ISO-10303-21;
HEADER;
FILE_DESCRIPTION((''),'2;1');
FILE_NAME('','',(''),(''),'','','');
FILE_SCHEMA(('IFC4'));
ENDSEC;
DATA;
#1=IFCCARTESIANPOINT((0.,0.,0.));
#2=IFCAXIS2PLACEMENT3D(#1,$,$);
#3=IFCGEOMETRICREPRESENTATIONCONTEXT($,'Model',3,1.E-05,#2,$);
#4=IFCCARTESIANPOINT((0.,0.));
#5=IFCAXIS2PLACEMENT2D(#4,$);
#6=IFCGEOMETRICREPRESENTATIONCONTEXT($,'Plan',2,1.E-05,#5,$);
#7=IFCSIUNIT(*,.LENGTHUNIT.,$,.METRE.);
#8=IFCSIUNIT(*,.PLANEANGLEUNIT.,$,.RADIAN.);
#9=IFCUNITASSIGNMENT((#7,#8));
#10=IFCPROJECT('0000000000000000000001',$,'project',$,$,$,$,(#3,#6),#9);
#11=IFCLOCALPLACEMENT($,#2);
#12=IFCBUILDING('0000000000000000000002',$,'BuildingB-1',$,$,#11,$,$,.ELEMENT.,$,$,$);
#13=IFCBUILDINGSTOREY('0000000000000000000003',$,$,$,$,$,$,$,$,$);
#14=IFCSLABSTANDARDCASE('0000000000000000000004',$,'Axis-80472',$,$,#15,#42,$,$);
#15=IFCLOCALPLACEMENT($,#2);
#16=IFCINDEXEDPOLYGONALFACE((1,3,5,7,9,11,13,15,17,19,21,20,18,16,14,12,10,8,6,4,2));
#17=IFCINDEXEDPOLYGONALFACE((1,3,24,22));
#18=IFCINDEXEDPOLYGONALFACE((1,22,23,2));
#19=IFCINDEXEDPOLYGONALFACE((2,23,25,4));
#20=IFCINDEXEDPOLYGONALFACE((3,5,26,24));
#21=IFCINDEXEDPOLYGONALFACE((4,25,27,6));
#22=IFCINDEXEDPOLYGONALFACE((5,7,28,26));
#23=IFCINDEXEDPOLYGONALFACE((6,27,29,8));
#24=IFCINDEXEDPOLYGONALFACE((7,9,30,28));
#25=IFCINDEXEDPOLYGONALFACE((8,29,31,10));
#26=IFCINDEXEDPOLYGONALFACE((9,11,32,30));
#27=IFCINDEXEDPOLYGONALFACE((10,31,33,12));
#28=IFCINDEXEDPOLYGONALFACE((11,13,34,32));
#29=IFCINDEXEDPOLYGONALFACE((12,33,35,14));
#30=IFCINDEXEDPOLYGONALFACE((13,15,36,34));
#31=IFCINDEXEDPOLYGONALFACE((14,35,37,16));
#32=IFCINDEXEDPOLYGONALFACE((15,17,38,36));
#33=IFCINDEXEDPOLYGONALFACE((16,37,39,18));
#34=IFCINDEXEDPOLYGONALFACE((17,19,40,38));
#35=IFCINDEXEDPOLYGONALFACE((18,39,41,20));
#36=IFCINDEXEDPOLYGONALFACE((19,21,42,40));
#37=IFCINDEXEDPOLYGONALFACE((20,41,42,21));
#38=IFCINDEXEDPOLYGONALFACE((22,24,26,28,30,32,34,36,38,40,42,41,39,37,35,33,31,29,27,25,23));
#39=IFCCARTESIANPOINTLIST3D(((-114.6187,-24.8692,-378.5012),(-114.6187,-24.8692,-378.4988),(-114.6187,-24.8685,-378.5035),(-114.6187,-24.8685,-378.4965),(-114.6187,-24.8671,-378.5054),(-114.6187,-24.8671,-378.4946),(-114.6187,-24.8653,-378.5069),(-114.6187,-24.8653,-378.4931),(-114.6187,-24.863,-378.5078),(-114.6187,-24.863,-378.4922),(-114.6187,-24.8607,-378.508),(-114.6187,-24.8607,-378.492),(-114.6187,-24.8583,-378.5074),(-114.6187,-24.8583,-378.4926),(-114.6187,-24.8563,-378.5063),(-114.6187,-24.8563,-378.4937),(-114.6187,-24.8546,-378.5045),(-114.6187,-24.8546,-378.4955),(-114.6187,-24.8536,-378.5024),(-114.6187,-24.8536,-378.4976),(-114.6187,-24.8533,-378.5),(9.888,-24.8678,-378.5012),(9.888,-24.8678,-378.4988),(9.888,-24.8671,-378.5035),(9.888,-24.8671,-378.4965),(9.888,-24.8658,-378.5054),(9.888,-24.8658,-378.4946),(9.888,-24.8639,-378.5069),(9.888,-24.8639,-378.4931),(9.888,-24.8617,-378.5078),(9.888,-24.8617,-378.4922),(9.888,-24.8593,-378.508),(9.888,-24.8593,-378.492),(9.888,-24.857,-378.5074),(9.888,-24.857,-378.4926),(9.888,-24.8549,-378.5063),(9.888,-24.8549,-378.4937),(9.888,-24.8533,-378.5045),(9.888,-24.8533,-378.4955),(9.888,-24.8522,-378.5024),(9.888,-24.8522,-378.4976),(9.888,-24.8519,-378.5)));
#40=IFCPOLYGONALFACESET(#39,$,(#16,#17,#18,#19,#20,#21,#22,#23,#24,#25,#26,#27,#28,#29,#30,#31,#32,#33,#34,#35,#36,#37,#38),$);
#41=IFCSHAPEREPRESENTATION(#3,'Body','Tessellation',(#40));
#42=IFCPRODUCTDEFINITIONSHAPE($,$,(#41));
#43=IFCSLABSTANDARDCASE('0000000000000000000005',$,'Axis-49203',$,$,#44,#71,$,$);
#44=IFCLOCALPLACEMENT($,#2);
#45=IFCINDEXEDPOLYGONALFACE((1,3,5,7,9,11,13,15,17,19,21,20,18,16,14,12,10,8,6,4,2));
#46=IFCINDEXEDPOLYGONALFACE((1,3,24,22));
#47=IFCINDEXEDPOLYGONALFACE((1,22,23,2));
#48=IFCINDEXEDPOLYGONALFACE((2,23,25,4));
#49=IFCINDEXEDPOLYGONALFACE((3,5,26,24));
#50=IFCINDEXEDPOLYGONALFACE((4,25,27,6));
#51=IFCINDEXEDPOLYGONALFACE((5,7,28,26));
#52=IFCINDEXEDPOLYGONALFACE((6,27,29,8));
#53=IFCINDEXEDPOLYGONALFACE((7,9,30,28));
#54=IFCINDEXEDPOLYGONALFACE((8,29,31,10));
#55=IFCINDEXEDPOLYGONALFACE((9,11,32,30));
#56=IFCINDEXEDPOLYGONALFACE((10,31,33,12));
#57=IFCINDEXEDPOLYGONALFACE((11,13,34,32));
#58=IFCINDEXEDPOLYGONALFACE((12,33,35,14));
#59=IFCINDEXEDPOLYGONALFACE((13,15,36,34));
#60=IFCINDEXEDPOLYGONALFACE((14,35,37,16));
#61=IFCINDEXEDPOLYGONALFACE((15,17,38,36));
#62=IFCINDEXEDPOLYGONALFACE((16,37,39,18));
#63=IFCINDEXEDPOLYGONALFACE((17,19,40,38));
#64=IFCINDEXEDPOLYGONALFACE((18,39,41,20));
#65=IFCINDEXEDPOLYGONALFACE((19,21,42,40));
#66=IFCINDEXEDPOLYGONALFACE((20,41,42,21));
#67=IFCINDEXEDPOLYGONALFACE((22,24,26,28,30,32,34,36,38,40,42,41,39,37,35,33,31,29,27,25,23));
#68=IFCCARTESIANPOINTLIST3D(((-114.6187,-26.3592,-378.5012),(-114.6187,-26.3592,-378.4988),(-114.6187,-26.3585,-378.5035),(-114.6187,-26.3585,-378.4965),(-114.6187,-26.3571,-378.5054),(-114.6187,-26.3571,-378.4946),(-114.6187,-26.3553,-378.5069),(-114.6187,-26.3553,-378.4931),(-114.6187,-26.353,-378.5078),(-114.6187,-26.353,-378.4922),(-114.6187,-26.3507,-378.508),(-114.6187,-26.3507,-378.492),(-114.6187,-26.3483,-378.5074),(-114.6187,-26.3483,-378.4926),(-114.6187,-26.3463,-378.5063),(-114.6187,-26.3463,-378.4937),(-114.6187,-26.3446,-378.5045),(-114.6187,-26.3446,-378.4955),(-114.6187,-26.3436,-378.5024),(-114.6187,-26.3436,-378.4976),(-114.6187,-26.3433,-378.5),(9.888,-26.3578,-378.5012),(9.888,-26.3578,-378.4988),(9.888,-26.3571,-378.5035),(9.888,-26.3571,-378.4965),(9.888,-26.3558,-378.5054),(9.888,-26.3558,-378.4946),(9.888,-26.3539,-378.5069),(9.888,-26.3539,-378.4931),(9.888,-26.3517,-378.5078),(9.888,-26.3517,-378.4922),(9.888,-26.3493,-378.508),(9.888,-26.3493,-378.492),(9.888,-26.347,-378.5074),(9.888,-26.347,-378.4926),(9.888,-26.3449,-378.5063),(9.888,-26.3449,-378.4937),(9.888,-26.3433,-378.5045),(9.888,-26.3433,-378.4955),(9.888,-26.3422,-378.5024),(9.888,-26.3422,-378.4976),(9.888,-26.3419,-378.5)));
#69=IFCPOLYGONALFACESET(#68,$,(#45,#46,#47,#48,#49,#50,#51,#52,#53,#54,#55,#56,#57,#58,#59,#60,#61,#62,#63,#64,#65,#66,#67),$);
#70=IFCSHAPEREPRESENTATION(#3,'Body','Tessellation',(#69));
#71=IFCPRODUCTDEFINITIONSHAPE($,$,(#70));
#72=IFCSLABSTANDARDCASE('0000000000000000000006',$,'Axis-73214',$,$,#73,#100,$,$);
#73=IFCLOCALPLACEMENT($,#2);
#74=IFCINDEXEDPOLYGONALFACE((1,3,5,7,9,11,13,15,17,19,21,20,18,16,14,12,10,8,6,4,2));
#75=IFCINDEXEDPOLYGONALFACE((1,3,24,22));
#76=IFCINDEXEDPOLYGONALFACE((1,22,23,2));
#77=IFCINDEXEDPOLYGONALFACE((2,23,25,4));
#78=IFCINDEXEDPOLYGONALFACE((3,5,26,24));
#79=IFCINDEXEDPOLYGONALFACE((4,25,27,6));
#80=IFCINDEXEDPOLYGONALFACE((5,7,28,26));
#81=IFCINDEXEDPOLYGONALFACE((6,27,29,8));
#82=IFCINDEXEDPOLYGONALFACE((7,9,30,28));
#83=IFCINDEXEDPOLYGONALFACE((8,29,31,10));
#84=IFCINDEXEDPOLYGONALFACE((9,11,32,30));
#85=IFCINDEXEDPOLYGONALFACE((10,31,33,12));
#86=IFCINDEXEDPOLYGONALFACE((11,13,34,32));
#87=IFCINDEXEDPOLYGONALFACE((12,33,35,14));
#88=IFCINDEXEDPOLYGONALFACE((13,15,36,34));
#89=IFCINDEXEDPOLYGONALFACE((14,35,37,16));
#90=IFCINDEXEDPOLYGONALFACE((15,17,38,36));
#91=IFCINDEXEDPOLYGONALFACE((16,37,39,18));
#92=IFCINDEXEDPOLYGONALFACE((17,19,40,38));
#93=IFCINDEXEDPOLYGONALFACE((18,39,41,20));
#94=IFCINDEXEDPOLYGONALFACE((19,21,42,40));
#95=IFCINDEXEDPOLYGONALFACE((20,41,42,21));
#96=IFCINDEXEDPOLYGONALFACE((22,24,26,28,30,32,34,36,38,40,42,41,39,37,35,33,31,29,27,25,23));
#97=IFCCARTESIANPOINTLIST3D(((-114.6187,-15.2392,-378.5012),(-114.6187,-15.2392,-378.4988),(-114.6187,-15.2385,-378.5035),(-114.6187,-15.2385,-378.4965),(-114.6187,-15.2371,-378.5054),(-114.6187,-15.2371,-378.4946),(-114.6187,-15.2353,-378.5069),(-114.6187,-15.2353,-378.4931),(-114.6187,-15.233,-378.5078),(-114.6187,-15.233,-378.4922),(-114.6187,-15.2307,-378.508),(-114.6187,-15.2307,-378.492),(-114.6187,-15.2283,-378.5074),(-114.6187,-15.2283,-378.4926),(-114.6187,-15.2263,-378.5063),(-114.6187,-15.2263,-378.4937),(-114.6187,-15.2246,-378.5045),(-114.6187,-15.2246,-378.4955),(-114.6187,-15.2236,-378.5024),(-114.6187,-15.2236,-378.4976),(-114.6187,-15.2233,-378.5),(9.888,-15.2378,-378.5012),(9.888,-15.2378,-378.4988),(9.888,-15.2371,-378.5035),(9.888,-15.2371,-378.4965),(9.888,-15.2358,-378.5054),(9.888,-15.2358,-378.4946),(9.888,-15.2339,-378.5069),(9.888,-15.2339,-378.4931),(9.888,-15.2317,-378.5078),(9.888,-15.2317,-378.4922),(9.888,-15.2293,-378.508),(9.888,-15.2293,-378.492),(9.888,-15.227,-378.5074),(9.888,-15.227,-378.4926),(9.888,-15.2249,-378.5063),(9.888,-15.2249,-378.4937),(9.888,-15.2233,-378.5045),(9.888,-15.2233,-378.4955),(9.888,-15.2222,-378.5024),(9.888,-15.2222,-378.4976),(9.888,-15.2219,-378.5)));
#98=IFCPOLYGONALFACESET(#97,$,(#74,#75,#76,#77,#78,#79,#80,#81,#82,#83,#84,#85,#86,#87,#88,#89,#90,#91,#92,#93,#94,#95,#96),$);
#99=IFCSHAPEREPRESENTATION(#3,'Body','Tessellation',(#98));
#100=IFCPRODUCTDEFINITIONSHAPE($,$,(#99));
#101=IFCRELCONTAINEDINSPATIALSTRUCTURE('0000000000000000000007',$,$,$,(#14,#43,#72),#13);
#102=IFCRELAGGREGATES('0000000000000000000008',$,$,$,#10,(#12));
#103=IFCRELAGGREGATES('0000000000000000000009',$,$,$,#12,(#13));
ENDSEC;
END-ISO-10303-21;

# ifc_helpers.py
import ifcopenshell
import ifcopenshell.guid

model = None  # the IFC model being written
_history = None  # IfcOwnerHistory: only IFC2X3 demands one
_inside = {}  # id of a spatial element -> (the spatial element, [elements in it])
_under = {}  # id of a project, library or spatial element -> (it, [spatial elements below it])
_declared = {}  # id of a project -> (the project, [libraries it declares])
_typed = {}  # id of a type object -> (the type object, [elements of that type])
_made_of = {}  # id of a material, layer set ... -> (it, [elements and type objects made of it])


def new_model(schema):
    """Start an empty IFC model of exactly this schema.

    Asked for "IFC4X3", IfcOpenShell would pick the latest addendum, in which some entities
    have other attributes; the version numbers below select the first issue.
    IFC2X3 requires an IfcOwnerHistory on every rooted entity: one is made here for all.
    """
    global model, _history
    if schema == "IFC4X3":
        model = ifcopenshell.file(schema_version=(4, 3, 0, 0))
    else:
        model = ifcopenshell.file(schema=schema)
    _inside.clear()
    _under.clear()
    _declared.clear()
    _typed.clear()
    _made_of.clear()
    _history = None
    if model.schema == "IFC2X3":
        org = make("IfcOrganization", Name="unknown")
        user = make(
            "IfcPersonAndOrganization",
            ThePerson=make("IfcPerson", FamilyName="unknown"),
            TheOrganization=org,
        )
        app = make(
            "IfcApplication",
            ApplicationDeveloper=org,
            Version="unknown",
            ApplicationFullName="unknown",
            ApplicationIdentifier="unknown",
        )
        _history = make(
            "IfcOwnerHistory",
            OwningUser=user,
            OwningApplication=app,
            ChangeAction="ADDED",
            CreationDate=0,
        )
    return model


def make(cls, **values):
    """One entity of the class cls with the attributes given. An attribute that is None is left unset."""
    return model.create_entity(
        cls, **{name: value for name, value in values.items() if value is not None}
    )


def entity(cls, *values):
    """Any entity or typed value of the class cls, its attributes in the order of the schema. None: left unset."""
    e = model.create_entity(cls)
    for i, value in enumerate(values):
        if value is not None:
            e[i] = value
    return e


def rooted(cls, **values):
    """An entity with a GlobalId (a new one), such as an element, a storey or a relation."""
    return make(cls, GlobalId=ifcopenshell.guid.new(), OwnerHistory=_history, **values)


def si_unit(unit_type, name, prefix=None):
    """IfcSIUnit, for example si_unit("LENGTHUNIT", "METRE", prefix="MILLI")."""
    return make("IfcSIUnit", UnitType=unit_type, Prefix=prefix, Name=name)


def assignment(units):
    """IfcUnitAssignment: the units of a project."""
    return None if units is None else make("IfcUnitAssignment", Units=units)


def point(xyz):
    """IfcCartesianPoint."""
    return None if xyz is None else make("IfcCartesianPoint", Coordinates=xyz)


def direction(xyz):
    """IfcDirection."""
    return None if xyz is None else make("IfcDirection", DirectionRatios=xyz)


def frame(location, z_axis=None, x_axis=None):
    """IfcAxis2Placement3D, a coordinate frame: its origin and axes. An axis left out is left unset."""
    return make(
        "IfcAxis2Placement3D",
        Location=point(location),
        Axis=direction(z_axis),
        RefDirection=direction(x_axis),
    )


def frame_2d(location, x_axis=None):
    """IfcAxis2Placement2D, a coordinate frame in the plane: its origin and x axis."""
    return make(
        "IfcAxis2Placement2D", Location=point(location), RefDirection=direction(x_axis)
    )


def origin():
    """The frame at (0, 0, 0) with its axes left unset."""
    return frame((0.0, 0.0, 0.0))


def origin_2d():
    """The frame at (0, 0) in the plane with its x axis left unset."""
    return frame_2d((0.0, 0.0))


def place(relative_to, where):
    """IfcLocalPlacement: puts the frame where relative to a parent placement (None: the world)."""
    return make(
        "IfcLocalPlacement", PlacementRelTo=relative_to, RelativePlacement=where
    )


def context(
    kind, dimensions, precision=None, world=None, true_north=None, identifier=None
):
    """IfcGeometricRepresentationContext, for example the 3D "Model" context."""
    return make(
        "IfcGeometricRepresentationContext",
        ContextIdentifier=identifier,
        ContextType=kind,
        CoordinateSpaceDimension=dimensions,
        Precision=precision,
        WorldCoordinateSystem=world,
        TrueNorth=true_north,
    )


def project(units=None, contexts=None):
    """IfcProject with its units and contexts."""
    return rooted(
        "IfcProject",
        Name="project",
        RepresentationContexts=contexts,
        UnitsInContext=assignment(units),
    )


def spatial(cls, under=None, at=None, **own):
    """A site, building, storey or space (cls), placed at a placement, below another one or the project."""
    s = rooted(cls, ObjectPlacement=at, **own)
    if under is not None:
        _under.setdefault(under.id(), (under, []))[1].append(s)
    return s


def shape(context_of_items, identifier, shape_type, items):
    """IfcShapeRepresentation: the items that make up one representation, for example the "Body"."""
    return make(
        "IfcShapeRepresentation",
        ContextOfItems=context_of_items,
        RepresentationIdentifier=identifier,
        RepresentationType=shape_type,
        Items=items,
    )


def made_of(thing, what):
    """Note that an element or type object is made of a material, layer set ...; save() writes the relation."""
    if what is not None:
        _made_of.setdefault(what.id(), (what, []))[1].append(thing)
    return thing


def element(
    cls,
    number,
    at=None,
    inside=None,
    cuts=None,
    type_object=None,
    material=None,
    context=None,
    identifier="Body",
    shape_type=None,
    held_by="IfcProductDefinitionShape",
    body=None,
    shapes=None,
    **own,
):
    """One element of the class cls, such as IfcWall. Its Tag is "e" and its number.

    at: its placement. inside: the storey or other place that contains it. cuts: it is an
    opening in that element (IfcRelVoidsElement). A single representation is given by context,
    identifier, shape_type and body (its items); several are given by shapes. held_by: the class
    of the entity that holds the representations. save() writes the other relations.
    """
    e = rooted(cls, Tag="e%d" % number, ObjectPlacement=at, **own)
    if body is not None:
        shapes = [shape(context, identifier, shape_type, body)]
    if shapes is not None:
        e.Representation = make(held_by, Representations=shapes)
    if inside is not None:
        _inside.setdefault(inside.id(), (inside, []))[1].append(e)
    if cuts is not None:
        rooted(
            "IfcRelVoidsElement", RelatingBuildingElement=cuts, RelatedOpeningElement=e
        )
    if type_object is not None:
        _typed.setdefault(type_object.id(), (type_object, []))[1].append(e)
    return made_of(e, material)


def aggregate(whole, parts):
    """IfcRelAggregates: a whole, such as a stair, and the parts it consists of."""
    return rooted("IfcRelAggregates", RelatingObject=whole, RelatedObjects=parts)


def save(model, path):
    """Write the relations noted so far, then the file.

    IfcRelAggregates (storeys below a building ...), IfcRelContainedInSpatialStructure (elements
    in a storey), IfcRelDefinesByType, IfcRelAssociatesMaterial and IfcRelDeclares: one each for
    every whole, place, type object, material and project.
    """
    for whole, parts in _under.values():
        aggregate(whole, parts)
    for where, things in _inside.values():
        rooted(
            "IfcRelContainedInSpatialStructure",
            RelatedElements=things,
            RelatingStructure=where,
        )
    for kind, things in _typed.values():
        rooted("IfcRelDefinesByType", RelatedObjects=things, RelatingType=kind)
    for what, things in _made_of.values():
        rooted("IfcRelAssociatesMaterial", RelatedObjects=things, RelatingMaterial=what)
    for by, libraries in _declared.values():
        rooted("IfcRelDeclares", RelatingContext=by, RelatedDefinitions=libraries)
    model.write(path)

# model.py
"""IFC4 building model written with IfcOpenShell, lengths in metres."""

from ifc_helpers import new_model, entity, si_unit, origin, origin_2d, place, context, project, spatial, element, save


model = new_model("IFC4")

# Units and contexts
model_context = context("Model", 3, precision=1e-05, world=origin())
plan_context = context("Plan", 2, precision=1e-05, world=origin_2d())
ifc_project = project(units=[si_unit("LENGTHUNIT", "METRE"), si_unit("PLANEANGLEUNIT", "RADIAN")], contexts=[model_context, plan_context])

# Building, storey
building_placement = place(None, origin())
building = spatial("IfcBuilding", under=ifc_project, at=building_placement, Name="BuildingB-1", CompositionType="ELEMENT")
storey = spatial("IfcBuildingStorey", under=building)

# Slabs
element("IfcSlabStandardCase", 1, inside=storey, Name="Axis-80472", context=model_context, shape_type="AdvancedSweptSolid", body=[
    entity("IfcSurfaceCurveSweptAreaSolid", entity("IfcCircleProfileDef", "AREA", None, None, 0.008), None, entity("IfcPolyline", [entity("IfcCartesianPoint", [-9.888, 24.8599, 378.5]), entity("IfcCartesianPoint", [114.6187, 24.8613, 378.5])]), None, None, entity("IfcPlane", entity("IfcAxis2Placement3D", entity("IfcCartesianPoint", [-9.888, 24.8599, 378.5]), entity("IfcDirection", [0.0, 0.0, 1.0]), entity("IfcDirection", [1.0, 0.0, 0.0])))),
    entity("IfcSurfaceCurveSweptAreaSolid", entity("IfcCircleProfileDef", "AREA", None, None, 0.008), None, entity("IfcCircle", entity("IfcAxis2Placement2D", entity("IfcCartesianPoint", [-10.1215, 24.8599, 378.5])), 0.35), None, None, entity("IfcPlane", entity("IfcAxis2Placement3D", entity("IfcCartesianPoint", [-10.1215, 24.8599, 378.5]), entity("IfcDirection", [0.0, 0.0, 1.0]), entity("IfcDirection", [1.0, 0.0, 0.0])))),
    entity("IfcSurfaceCurveSweptAreaSolid", entity("IfcCircleProfileDef", "AREA", None, None, 0.008), None, entity("IfcCircle", entity("IfcAxis2Placement2D", entity("IfcCartesianPoint", [114.8522, 24.8613, 378.5])), 0.35), None, None, entity("IfcPlane", entity("IfcAxis2Placement3D", entity("IfcCartesianPoint", [114.8522, 24.8613, 378.5]), entity("IfcDirection", [0.0, 0.0, 1.0]), entity("IfcDirection", [1.0, 0.0, 0.0])))),
])
element("IfcSlabStandardCase", 2, inside=storey, Name="Axis-49203", context=model_context, shape_type="AdvancedSweptSolid", body=[
    entity("IfcSurfaceCurveSweptAreaSolid", entity("IfcCircleProfileDef", "AREA", None, None, 0.008), None, entity("IfcPolyline", [entity("IfcCartesianPoint", [-9.888, 26.3499, 378.5]), entity("IfcCartesianPoint", [114.6187, 26.3513, 378.5])]), None, None, entity("IfcPlane", entity("IfcAxis2Placement3D", entity("IfcCartesianPoint", [-9.888, 26.3499, 378.5]), entity("IfcDirection", [0.0, 0.0, 1.0]), entity("IfcDirection", [1.0, 0.0, 0.0])))),
    entity("IfcSurfaceCurveSweptAreaSolid", entity("IfcCircleProfileDef", "AREA", None, None, 0.008), None, entity("IfcCircle", entity("IfcAxis2Placement2D", entity("IfcCartesianPoint", [-10.1215, 26.3499, 378.5])), 0.35), None, None, entity("IfcPlane", entity("IfcAxis2Placement3D", entity("IfcCartesianPoint", [-10.1215, 26.3499, 378.5]), entity("IfcDirection", [0.0, 0.0, 1.0]), entity("IfcDirection", [1.0, 0.0, 0.0])))),
    entity("IfcSurfaceCurveSweptAreaSolid", entity("IfcCircleProfileDef", "AREA", None, None, 0.008), None, entity("IfcCircle", entity("IfcAxis2Placement2D", entity("IfcCartesianPoint", [114.8522, 26.3513, 378.5])), 0.35), None, None, entity("IfcPlane", entity("IfcAxis2Placement3D", entity("IfcCartesianPoint", [114.8522, 26.3513, 378.5]), entity("IfcDirection", [0.0, 0.0, 1.0]), entity("IfcDirection", [1.0, 0.0, 0.0])))),
])
element("IfcSlabStandardCase", 3, inside=storey, Name="Axis-73214", context=model_context, shape_type="AdvancedSweptSolid", body=[
    entity("IfcSurfaceCurveSweptAreaSolid", entity("IfcCircleProfileDef", "AREA", None, None, 0.008), None, entity("IfcPolyline", [entity("IfcCartesianPoint", [-9.888, 15.2299, 378.5]), entity("IfcCartesianPoint", [114.6187, 15.2313, 378.5])]), None, None, entity("IfcPlane", entity("IfcAxis2Placement3D", entity("IfcCartesianPoint", [-9.888, 15.2299, 378.5]), entity("IfcDirection", [0.0, 0.0, 1.0]), entity("IfcDirection", [1.0, 0.0, 0.0])))),
    entity("IfcSurfaceCurveSweptAreaSolid", entity("IfcCircleProfileDef", "AREA", None, None, 0.008), None, entity("IfcCircle", entity("IfcAxis2Placement2D", entity("IfcCartesianPoint", [-10.1217, 15.2299, 378.5])), 0.35), None, None, entity("IfcPlane", entity("IfcAxis2Placement3D", entity("IfcCartesianPoint", [-10.1217, 15.2299, 378.5]), entity("IfcDirection", [0.0, 0.0, 1.0]), entity("IfcDirection", [1.0, 0.0, 0.0])))),
    entity("IfcSurfaceCurveSweptAreaSolid", entity("IfcCircleProfileDef", "AREA", None, None, 0.008), None, entity("IfcCircle", entity("IfcAxis2Placement2D", entity("IfcCartesianPoint", [114.8519, 15.2313, 378.5])), 0.35), None, None, entity("IfcPlane", entity("IfcAxis2Placement3D", entity("IfcCartesianPoint", [114.8519, 15.2313, 378.5]), entity("IfcDirection", [0.0, 0.0, 1.0]), entity("IfcDirection", [1.0, 0.0, 0.0])))),
])

save(model, "model.ifc")
